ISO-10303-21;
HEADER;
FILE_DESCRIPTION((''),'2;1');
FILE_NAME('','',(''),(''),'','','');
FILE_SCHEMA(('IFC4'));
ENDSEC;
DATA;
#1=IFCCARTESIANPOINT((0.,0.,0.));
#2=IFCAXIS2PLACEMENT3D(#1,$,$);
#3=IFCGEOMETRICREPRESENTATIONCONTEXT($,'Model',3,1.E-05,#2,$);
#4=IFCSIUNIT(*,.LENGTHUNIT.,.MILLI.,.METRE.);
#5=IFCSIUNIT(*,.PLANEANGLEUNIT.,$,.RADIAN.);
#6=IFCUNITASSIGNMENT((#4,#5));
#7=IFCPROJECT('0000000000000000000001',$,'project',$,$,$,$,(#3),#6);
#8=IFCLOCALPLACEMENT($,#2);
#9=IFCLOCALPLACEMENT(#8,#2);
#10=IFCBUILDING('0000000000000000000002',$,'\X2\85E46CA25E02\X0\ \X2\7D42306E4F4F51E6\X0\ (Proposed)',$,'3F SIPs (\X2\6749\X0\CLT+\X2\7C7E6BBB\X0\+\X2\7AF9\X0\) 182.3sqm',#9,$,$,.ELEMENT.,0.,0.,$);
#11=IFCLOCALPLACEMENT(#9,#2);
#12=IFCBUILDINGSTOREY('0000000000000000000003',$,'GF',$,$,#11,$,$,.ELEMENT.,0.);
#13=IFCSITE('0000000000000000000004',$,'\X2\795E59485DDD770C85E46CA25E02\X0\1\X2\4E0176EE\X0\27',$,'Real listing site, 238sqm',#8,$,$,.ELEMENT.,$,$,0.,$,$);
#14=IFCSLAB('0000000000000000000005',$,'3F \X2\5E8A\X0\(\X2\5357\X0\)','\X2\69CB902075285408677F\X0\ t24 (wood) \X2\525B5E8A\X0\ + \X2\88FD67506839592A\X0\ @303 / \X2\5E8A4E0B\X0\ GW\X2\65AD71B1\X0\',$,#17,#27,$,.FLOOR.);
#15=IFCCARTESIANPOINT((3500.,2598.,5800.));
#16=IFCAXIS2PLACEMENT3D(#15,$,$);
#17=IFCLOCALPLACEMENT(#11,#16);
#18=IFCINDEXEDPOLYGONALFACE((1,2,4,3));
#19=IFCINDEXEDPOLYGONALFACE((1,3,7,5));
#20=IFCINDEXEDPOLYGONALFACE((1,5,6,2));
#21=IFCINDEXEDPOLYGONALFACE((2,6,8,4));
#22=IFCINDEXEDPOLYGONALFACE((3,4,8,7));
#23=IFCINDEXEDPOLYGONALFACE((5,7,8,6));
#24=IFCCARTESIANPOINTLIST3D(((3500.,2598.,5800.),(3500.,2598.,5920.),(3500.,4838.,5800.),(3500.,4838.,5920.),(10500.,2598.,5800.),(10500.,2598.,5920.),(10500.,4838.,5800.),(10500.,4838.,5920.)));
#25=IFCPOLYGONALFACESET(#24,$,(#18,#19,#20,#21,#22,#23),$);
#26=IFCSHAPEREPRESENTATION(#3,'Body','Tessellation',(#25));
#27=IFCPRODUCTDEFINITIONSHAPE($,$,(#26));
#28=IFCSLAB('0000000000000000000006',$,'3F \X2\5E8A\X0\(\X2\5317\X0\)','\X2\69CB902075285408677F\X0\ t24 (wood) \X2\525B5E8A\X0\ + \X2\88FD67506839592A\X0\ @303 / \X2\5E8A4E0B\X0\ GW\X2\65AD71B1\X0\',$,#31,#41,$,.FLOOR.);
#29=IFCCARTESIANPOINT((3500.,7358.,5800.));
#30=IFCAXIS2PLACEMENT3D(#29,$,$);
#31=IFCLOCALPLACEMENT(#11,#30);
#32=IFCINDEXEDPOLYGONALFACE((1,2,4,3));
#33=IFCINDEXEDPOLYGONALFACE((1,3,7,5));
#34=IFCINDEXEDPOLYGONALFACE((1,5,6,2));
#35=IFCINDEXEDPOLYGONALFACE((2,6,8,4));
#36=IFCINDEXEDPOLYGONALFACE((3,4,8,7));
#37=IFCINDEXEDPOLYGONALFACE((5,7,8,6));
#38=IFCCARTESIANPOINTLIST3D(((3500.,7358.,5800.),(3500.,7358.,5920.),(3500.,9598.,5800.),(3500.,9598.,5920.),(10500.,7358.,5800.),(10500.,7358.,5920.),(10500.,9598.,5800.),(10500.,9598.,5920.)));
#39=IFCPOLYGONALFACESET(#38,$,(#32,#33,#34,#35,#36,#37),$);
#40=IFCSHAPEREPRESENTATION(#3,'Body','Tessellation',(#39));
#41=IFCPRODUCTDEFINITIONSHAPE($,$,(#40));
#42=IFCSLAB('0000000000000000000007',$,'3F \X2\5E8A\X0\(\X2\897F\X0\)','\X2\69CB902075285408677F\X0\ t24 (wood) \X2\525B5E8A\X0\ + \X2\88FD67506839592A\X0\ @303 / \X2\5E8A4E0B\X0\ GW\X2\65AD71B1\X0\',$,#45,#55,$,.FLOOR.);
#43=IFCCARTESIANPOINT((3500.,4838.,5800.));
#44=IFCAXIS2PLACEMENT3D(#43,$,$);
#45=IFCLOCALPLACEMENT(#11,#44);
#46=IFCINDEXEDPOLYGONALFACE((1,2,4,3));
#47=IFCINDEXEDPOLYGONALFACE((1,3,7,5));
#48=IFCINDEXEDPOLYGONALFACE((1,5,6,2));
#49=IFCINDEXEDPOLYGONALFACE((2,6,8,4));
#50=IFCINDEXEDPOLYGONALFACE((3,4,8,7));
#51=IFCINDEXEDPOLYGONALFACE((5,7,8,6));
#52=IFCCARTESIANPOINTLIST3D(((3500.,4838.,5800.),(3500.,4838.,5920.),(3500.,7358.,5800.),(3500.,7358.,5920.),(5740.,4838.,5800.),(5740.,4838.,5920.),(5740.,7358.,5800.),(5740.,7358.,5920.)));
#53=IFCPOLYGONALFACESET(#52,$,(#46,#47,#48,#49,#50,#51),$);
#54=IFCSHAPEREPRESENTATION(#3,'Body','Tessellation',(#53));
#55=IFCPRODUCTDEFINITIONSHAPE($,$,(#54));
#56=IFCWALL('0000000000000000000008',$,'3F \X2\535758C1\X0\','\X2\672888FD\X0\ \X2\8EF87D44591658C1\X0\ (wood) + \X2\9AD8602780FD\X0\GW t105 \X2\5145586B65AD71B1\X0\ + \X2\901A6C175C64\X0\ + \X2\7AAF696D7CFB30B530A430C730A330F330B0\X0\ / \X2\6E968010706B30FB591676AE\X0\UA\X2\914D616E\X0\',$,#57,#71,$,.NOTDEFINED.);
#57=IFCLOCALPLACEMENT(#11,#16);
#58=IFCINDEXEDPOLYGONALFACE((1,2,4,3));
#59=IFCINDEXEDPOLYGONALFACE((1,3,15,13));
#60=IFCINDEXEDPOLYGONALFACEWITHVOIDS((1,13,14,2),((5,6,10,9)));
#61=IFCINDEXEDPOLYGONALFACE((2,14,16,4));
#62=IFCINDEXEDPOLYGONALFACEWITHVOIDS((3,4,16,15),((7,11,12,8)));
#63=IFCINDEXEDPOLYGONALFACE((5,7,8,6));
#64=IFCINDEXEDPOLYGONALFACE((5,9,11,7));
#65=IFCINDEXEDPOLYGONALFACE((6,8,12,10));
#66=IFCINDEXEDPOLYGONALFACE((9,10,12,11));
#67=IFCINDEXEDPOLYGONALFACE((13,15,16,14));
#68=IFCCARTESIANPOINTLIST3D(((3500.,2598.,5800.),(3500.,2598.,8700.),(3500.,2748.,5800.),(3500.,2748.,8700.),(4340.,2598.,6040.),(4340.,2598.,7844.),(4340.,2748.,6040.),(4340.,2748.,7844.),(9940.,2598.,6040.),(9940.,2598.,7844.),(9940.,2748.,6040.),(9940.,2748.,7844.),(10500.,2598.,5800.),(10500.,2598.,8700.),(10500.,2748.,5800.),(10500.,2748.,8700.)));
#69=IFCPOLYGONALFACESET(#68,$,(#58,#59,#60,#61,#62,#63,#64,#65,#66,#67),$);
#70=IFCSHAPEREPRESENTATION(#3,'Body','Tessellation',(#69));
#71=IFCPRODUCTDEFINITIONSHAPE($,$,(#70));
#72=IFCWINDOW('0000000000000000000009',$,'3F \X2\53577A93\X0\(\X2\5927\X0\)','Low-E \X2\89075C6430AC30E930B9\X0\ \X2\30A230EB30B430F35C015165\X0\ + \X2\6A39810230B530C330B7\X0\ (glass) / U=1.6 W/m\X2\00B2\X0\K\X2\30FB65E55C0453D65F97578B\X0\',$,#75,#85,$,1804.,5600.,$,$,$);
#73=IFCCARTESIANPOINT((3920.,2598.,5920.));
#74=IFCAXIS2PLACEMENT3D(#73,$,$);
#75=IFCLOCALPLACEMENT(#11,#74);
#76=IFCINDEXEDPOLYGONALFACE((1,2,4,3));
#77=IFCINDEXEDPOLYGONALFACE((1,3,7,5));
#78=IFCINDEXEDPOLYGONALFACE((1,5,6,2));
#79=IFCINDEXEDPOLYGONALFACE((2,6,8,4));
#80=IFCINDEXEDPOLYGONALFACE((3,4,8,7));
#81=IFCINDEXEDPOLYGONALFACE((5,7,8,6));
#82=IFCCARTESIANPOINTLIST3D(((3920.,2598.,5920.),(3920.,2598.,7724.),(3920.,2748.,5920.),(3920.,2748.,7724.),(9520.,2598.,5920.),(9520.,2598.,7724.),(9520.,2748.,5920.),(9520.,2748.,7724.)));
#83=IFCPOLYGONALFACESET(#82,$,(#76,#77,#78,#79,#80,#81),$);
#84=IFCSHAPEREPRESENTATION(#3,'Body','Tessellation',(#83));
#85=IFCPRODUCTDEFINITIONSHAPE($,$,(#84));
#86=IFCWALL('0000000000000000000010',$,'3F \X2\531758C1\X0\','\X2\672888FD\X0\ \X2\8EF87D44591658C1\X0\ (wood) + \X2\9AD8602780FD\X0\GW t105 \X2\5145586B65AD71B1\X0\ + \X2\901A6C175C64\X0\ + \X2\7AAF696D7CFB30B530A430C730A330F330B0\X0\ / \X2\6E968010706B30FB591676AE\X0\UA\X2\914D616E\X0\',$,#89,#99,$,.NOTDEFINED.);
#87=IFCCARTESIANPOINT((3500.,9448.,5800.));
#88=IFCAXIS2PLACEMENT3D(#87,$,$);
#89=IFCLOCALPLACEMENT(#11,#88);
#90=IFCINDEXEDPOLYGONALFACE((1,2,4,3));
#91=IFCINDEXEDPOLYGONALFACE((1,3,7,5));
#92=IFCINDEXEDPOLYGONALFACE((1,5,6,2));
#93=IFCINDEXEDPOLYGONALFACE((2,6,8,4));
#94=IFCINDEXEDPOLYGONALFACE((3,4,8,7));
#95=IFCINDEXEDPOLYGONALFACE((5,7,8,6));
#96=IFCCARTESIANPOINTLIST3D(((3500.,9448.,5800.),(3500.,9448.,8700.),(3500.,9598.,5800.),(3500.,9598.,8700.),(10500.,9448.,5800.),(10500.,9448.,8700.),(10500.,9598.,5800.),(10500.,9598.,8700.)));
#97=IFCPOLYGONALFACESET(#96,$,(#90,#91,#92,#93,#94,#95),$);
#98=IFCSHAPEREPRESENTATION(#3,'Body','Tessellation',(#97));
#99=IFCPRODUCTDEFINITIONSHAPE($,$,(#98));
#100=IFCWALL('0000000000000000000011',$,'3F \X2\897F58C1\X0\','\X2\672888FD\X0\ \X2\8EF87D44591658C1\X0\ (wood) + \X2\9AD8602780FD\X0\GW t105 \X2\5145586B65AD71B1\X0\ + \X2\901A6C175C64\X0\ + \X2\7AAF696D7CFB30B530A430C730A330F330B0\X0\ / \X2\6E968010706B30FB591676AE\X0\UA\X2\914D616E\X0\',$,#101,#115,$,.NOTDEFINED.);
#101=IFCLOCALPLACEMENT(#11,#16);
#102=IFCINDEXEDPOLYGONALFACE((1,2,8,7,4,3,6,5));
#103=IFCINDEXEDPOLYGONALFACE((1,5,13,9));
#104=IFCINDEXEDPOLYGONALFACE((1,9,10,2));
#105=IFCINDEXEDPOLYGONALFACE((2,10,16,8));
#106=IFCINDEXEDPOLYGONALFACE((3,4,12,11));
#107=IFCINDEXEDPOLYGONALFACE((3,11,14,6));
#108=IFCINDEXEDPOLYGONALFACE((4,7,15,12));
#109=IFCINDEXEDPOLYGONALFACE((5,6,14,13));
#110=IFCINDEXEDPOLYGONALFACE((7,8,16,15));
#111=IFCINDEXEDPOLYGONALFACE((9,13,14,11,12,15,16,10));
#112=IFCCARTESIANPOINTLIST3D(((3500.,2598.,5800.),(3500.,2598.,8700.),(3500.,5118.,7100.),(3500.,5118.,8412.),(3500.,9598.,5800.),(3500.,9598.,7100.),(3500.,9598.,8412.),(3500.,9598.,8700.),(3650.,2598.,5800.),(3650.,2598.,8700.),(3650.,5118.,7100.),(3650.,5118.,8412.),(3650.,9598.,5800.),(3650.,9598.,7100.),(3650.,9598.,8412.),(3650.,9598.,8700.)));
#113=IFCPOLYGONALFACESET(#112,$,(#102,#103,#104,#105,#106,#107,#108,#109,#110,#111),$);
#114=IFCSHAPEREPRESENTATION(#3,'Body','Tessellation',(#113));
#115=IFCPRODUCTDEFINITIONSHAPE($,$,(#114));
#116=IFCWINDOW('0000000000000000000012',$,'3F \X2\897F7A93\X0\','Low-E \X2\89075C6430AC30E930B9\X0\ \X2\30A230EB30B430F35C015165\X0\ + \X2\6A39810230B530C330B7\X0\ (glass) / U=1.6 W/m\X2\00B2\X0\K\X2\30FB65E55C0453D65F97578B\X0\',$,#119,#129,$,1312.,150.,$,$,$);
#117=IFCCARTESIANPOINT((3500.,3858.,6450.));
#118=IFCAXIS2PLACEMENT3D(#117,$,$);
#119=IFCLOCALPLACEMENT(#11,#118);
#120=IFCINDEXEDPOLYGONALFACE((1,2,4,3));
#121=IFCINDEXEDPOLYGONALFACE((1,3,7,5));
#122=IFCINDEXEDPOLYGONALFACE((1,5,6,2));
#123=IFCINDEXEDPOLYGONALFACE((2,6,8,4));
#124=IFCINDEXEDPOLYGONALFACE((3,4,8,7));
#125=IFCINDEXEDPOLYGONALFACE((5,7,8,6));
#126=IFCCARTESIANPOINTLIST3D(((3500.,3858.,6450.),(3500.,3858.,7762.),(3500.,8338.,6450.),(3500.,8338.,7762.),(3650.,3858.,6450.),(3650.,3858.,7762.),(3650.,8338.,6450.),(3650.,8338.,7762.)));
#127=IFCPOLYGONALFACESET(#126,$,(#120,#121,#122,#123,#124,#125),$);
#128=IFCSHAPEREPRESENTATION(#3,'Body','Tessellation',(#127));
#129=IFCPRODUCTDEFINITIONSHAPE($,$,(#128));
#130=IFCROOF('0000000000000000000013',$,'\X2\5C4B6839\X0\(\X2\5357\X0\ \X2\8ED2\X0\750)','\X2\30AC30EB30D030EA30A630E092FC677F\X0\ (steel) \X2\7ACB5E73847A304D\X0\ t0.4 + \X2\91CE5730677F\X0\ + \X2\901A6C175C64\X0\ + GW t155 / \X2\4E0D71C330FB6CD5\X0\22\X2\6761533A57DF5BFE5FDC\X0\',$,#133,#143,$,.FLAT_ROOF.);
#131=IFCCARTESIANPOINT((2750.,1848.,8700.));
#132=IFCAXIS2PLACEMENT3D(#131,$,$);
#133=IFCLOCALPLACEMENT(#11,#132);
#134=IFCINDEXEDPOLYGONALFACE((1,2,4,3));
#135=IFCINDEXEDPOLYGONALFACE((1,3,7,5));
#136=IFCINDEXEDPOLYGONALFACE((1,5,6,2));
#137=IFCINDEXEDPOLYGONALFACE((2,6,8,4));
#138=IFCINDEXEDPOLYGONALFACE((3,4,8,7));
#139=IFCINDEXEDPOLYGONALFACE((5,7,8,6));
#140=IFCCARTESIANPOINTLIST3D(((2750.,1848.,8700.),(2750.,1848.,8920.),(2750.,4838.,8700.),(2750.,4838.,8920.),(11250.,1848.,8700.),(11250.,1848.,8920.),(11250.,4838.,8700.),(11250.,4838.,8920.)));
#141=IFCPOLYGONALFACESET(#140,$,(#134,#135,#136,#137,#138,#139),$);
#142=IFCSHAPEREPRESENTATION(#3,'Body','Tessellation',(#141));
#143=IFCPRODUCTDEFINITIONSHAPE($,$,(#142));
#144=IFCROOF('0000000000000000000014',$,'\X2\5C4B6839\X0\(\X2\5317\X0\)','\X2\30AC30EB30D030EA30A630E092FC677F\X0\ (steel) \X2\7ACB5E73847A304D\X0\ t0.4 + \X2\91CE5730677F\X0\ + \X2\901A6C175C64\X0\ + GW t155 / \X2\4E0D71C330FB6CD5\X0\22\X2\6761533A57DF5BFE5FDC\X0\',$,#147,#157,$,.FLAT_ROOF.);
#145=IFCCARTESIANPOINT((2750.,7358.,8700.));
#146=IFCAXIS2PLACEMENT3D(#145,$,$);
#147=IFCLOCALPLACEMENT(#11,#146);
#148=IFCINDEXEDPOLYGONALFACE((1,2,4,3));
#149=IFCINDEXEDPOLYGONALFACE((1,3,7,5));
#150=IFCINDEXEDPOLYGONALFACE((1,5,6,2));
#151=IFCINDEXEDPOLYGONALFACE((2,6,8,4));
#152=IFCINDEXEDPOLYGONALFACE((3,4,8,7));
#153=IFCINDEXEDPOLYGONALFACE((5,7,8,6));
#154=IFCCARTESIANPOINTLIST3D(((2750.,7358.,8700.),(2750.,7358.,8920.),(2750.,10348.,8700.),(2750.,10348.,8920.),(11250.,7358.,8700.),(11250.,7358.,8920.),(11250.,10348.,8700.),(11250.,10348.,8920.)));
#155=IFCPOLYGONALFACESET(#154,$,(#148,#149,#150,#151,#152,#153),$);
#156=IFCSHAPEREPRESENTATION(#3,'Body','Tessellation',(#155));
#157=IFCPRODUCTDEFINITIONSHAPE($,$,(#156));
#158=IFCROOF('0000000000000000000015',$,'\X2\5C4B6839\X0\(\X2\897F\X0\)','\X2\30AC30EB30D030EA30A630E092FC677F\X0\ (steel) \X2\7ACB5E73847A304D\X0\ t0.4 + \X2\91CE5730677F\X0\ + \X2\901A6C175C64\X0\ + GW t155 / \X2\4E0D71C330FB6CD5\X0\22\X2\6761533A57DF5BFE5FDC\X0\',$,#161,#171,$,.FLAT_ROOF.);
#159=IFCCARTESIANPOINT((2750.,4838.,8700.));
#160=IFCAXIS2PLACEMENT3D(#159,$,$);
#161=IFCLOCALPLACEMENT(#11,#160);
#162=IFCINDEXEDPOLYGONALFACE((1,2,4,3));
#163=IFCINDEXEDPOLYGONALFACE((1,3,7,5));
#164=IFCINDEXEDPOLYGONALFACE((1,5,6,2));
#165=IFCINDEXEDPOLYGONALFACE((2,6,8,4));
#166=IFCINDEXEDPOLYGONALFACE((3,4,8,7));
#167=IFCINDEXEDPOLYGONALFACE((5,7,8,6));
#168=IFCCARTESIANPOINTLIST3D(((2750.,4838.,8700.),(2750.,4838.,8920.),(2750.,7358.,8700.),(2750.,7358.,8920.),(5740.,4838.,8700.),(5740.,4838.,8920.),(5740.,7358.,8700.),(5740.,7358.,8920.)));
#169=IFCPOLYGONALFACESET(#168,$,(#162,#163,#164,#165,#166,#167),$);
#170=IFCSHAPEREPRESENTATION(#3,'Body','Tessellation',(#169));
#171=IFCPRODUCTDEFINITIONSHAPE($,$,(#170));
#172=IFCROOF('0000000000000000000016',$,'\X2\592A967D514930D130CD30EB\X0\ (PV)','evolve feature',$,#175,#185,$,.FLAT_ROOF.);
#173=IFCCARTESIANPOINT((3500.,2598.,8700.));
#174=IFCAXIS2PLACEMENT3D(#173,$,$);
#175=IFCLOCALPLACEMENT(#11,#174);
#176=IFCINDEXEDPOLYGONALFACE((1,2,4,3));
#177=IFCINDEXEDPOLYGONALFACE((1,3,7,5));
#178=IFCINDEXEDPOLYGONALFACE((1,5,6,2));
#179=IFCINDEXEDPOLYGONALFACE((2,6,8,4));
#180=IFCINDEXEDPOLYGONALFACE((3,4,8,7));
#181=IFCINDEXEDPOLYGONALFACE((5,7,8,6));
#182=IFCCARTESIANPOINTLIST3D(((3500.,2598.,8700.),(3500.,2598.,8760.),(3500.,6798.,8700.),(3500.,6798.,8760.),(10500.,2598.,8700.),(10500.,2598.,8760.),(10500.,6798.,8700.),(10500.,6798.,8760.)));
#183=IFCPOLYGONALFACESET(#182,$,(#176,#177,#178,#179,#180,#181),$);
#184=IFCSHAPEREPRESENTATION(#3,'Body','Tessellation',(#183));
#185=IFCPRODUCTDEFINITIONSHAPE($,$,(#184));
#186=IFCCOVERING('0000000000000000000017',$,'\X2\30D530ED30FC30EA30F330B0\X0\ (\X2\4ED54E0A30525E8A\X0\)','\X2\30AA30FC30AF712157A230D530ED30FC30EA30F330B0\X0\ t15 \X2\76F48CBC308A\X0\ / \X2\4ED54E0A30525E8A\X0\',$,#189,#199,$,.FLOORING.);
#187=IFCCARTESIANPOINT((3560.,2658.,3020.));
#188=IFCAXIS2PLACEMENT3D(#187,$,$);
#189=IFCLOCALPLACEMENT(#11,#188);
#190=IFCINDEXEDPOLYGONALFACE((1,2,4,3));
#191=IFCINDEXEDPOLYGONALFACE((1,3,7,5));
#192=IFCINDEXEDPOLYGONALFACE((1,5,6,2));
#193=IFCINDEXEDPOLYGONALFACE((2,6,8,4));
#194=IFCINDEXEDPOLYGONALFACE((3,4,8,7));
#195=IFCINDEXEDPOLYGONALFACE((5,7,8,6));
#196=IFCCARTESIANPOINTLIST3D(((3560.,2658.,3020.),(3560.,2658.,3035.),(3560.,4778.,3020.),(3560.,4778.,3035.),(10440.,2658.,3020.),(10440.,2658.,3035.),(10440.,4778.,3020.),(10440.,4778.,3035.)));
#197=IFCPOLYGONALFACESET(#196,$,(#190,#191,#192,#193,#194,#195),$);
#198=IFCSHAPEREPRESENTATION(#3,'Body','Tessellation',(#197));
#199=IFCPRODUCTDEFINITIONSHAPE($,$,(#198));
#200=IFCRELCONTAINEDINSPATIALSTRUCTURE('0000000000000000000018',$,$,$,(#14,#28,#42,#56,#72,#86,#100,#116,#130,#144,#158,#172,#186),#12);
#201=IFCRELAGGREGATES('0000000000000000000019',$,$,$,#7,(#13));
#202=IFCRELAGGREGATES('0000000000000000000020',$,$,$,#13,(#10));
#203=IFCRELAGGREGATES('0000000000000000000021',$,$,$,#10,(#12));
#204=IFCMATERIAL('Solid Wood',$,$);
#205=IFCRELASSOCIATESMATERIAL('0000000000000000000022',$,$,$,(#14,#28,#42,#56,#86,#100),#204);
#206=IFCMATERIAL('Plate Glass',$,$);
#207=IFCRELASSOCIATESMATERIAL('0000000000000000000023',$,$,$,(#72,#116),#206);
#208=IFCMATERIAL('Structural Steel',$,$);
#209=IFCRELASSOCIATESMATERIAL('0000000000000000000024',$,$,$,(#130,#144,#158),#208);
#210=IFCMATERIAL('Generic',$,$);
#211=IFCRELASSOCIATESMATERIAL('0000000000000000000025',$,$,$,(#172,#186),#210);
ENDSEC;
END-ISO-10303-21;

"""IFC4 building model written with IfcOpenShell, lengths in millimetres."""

from ifc_helpers import new_model, si_unit, frame, frame_2d, origin, place, context, project, spatial, rectangle, extrude, material, element, fill, save


model = new_model("IFC4")

# Units and contexts
model_context = context("Model", 3, precision=1e-05, world=origin())
ifc_project = project(units=[si_unit("LENGTHUNIT", "METRE", prefix="MILLI"), si_unit("PLANEANGLEUNIT", "RADIAN")], contexts=[model_context])

# Site, building, storey
site_placement = place(None, origin())
site = spatial("IfcSite", under=ifc_project, at=site_placement, Name="神奈川県藤沢市1丁目27", ObjectType="Real listing site, 238sqm", CompositionType="ELEMENT", RefElevation=0.0)
building_placement = place(site_placement, origin())
building = spatial("IfcBuilding", under=site, at=building_placement, Name="藤沢市 終の住処 (Proposed)", ObjectType="3F SIPs (杉CLT+籾殻+竹) 182.3sqm", CompositionType="ELEMENT", ElevationOfRefHeight=0.0, ElevationOfTerrain=0.0)
storey_placement = place(building_placement, origin())
storey = spatial("IfcBuildingStorey", under=building, at=storey_placement, Name="GF", CompositionType="ELEMENT", Elevation=0.0)

# Slabs
ifc_material_1 = material(Name="Solid Wood")
slab_1_placement = place(storey_placement, frame((3500.0, 2598.0, 5800.0)))
element("IfcSlab", 1, at=slab_1_placement, inside=storey, material=ifc_material_1, Name="3F 床(南)", Description="構造用合板 t24 (wood) 剛床 + 製材根太 @303 / 床下 GW断熱", PredefinedType="FLOOR", context=model_context, shape_type="SweptSolid", body=[
    extrude(rectangle(XDim=7000.0, YDim=2240.0, at=frame_2d((3500.0, 1120.0))), frame((3500.0, 2598.0, 5800.0)), (0.0, 0.0, 1.0), 120.0),
])
slab_2_placement = place(storey_placement, frame((3500.0, 7358.0, 5800.0)))
element("IfcSlab", 2, at=slab_2_placement, inside=storey, material=ifc_material_1, Name="3F 床(北)", Description="構造用合板 t24 (wood) 剛床 + 製材根太 @303 / 床下 GW断熱", PredefinedType="FLOOR", context=model_context, shape_type="SweptSolid", body=[
    extrude(rectangle(XDim=7000.0, YDim=2240.0, at=frame_2d((3500.0, 1120.0))), frame((3500.0, 7358.0, 5800.0)), (0.0, 0.0, 1.0), 120.0),
])
slab_3_placement = place(storey_placement, frame((3500.0, 4838.0, 5800.0)))
element("IfcSlab", 3, at=slab_3_placement, inside=storey, material=ifc_material_1, Name="3F 床(西)", Description="構造用合板 t24 (wood) 剛床 + 製材根太 @303 / 床下 GW断熱", PredefinedType="FLOOR", context=model_context, shape_type="SweptSolid", body=[
    extrude(rectangle(XDim=2240.0, YDim=2520.0, at=frame_2d((1120.0, 1260.0))), frame((3500.0, 4838.0, 5800.0)), (0.0, 0.0, 1.0), 120.0),
])

# Wall, opening, window
wall_1_placement = place(storey_placement, frame((3500.0, 2598.0, 5800.0)))
wall_1 = element("IfcWall", 4, at=wall_1_placement, inside=storey, material=ifc_material_1, Name="3F 南壁", Description="木製 軸組外壁 (wood) + 高性能GW t105 充填断熱 + 通気層 + 窯業系サイディング / 準耐火・外皮UA配慮", PredefinedType="NOTDEFINED", context=model_context, shape_type="SweptSolid", body=[
    extrude(rectangle(XDim=7000.0, YDim=150.0, at=frame_2d((3500.0, 75.0))), frame((3500.0, 2598.0, 5800.0)), (0.0, 0.0, 1.0), 2900.0),
])
opening_1_placement = place(storey_placement, frame((3920.0, 2598.0, 5920.0)))
opening_1 = element("IfcOpeningElement", 5, at=opening_1_placement, cuts=wall_1, PredefinedType="NOTDEFINED", context=model_context, shape_type="SweptSolid", body=[
    extrude(rectangle(XDim=5600.0, YDim=150.0, at=frame_2d((2800.0, 75.0))), frame((3920.0, 2598.0, 5920.0)), (0.0, 0.0, 1.0), 1804.0),
])
ifc_material_2 = material(Name="Plate Glass")
window_1_placement = place(storey_placement, frame((3920.0, 2598.0, 5920.0)))
window_1 = element("IfcWindow", 6, at=window_1_placement, inside=storey, material=ifc_material_2, Name="3F 南窓(大)", Description="Low-E 複層ガラス アルゴン封入 + 樹脂サッシ (glass) / U=1.6 W/m²K・日射取得型", OverallHeight=1804.0, OverallWidth=5600.0, context=model_context, shape_type="SweptSolid", body=[
    extrude(rectangle(XDim=5600.0, YDim=150.0, at=frame_2d((2800.0, 75.0))), frame((3920.0, 2598.0, 5920.0)), (0.0, 0.0, 1.0), 1804.0),
])
fill(opening_1, window_1)

# Wall
wall_2_placement = place(storey_placement, frame((3500.0, 9448.0, 5800.0)))
element("IfcWall", 7, at=wall_2_placement, inside=storey, material=ifc_material_1, Name="3F 北壁", Description="木製 軸組外壁 (wood) + 高性能GW t105 充填断熱 + 通気層 + 窯業系サイディング / 準耐火・外皮UA配慮", PredefinedType="NOTDEFINED", context=model_context, shape_type="SweptSolid", body=[
    extrude(rectangle(XDim=7000.0, YDim=150.0, at=frame_2d((3500.0, 75.0))), frame((3500.0, 9448.0, 5800.0)), (0.0, 0.0, 1.0), 2900.0),
])

# Wall, opening, window
wall_3_placement = place(storey_placement, frame((3500.0, 2598.0, 5800.0)))
wall_3 = element("IfcWall", 8, at=wall_3_placement, inside=storey, material=ifc_material_1, Name="3F 西壁", Description="木製 軸組外壁 (wood) + 高性能GW t105 充填断熱 + 通気層 + 窯業系サイディング / 準耐火・外皮UA配慮", PredefinedType="NOTDEFINED", context=model_context, shape_type="SweptSolid", body=[
    extrude(rectangle(XDim=150.0, YDim=7000.0, at=frame_2d((75.0, 3500.0))), frame((3500.0, 2598.0, 5800.0)), (0.0, 0.0, 1.0), 2900.0),
])
opening_2_placement = place(storey_placement, frame((3500.0, 3858.0, 6450.0)))
opening_2 = element("IfcOpeningElement", 9, at=opening_2_placement, cuts=wall_3, PredefinedType="NOTDEFINED", context=model_context, shape_type="SweptSolid", body=[
    extrude(rectangle(XDim=150.0, YDim=4480.0, at=frame_2d((75.0, 2240.0))), frame((3500.0, 3858.0, 6450.0)), (0.0, 0.0, 1.0), 1312.0),
])
window_2_placement = place(storey_placement, frame((3500.0, 3858.0, 6450.0)))
window_2 = element("IfcWindow", 10, at=window_2_placement, inside=storey, material=ifc_material_2, Name="3F 西窓", Description="Low-E 複層ガラス アルゴン封入 + 樹脂サッシ (glass) / U=1.6 W/m²K・日射取得型", OverallHeight=1312.0, OverallWidth=150.0, context=model_context, shape_type="SweptSolid", body=[
    extrude(rectangle(XDim=150.0, YDim=4480.0, at=frame_2d((75.0, 2240.0))), frame((3500.0, 3858.0, 6450.0)), (0.0, 0.0, 1.0), 1312.0),
])
fill(opening_2, window_2)

# Roofs
ifc_material_3 = material(Name="Structural Steel")
roof_1_placement = place(storey_placement, frame((2750.0, 1848.0, 8700.0)))
element("IfcRoof", 11, at=roof_1_placement, inside=storey, material=ifc_material_3, Name="屋根(南 軒750)", Description="ガルバリウム鋼板 (steel) 立平葺き t0.4 + 野地板 + 通気層 + GW t155 / 不燃・法22条区域対応", PredefinedType="FLAT_ROOF", context=model_context, shape_type="SweptSolid", body=[
    extrude(rectangle(XDim=8500.0, YDim=2990.0, at=frame_2d((4250.0, 1495.0))), frame((2750.0, 1848.0, 8700.0)), (0.0, 0.0, 1.0), 220.0),
])
roof_2_placement = place(storey_placement, frame((2750.0, 7358.0, 8700.0)))
element("IfcRoof", 12, at=roof_2_placement, inside=storey, material=ifc_material_3, Name="屋根(北)", Description="ガルバリウム鋼板 (steel) 立平葺き t0.4 + 野地板 + 通気層 + GW t155 / 不燃・法22条区域対応", PredefinedType="FLAT_ROOF", context=model_context, shape_type="SweptSolid", body=[
    extrude(rectangle(XDim=8500.0, YDim=2990.0, at=frame_2d((4250.0, 1495.0))), frame((2750.0, 7358.0, 8700.0)), (0.0, 0.0, 1.0), 220.0),
])
roof_3_placement = place(storey_placement, frame((2750.0, 4838.0, 8700.0)))
element("IfcRoof", 13, at=roof_3_placement, inside=storey, material=ifc_material_3, Name="屋根(西)", Description="ガルバリウム鋼板 (steel) 立平葺き t0.4 + 野地板 + 通気層 + GW t155 / 不燃・法22条区域対応", PredefinedType="FLAT_ROOF", context=model_context, shape_type="SweptSolid", body=[
    extrude(rectangle(XDim=2990.0, YDim=2520.0, at=frame_2d((1495.0, 1260.0))), frame((2750.0, 4838.0, 8700.0)), (0.0, 0.0, 1.0), 220.0),
])
ifc_material_4 = material(Name="Generic")
roof_4_placement = place(storey_placement, frame((3500.0, 2598.0, 8700.0)))
element("IfcRoof", 14, at=roof_4_placement, inside=storey, material=ifc_material_4, Name="太陽光パネル (PV)", Description="evolve feature", PredefinedType="FLAT_ROOF", context=model_context, shape_type="SweptSolid", body=[
    extrude(rectangle(XDim=7000.0, YDim=4200.0, at=frame_2d((3500.0, 2100.0))), frame((3500.0, 2598.0, 8700.0)), (0.0, 0.0, 1.0), 60.0),
])

# Covering
covering_1_placement = place(storey_placement, frame((3560.0, 2658.0, 3020.0)))
element("IfcCovering", 15, at=covering_1_placement, inside=storey, material=ifc_material_4, Name="フローリング (仕上げ床)", Description="オーク無垢フローリング t15 直貼り / 仕上げ床", PredefinedType="FLOORING", context=model_context, shape_type="SweptSolid", body=[
    extrude(rectangle(XDim=6880.0, YDim=2120.0, at=frame_2d((3440.0, 1060.0))), frame((3560.0, 2658.0, 3020.0)), (0.0, 0.0, 1.0), 15.0),
])

save(model, "model.ifc")
